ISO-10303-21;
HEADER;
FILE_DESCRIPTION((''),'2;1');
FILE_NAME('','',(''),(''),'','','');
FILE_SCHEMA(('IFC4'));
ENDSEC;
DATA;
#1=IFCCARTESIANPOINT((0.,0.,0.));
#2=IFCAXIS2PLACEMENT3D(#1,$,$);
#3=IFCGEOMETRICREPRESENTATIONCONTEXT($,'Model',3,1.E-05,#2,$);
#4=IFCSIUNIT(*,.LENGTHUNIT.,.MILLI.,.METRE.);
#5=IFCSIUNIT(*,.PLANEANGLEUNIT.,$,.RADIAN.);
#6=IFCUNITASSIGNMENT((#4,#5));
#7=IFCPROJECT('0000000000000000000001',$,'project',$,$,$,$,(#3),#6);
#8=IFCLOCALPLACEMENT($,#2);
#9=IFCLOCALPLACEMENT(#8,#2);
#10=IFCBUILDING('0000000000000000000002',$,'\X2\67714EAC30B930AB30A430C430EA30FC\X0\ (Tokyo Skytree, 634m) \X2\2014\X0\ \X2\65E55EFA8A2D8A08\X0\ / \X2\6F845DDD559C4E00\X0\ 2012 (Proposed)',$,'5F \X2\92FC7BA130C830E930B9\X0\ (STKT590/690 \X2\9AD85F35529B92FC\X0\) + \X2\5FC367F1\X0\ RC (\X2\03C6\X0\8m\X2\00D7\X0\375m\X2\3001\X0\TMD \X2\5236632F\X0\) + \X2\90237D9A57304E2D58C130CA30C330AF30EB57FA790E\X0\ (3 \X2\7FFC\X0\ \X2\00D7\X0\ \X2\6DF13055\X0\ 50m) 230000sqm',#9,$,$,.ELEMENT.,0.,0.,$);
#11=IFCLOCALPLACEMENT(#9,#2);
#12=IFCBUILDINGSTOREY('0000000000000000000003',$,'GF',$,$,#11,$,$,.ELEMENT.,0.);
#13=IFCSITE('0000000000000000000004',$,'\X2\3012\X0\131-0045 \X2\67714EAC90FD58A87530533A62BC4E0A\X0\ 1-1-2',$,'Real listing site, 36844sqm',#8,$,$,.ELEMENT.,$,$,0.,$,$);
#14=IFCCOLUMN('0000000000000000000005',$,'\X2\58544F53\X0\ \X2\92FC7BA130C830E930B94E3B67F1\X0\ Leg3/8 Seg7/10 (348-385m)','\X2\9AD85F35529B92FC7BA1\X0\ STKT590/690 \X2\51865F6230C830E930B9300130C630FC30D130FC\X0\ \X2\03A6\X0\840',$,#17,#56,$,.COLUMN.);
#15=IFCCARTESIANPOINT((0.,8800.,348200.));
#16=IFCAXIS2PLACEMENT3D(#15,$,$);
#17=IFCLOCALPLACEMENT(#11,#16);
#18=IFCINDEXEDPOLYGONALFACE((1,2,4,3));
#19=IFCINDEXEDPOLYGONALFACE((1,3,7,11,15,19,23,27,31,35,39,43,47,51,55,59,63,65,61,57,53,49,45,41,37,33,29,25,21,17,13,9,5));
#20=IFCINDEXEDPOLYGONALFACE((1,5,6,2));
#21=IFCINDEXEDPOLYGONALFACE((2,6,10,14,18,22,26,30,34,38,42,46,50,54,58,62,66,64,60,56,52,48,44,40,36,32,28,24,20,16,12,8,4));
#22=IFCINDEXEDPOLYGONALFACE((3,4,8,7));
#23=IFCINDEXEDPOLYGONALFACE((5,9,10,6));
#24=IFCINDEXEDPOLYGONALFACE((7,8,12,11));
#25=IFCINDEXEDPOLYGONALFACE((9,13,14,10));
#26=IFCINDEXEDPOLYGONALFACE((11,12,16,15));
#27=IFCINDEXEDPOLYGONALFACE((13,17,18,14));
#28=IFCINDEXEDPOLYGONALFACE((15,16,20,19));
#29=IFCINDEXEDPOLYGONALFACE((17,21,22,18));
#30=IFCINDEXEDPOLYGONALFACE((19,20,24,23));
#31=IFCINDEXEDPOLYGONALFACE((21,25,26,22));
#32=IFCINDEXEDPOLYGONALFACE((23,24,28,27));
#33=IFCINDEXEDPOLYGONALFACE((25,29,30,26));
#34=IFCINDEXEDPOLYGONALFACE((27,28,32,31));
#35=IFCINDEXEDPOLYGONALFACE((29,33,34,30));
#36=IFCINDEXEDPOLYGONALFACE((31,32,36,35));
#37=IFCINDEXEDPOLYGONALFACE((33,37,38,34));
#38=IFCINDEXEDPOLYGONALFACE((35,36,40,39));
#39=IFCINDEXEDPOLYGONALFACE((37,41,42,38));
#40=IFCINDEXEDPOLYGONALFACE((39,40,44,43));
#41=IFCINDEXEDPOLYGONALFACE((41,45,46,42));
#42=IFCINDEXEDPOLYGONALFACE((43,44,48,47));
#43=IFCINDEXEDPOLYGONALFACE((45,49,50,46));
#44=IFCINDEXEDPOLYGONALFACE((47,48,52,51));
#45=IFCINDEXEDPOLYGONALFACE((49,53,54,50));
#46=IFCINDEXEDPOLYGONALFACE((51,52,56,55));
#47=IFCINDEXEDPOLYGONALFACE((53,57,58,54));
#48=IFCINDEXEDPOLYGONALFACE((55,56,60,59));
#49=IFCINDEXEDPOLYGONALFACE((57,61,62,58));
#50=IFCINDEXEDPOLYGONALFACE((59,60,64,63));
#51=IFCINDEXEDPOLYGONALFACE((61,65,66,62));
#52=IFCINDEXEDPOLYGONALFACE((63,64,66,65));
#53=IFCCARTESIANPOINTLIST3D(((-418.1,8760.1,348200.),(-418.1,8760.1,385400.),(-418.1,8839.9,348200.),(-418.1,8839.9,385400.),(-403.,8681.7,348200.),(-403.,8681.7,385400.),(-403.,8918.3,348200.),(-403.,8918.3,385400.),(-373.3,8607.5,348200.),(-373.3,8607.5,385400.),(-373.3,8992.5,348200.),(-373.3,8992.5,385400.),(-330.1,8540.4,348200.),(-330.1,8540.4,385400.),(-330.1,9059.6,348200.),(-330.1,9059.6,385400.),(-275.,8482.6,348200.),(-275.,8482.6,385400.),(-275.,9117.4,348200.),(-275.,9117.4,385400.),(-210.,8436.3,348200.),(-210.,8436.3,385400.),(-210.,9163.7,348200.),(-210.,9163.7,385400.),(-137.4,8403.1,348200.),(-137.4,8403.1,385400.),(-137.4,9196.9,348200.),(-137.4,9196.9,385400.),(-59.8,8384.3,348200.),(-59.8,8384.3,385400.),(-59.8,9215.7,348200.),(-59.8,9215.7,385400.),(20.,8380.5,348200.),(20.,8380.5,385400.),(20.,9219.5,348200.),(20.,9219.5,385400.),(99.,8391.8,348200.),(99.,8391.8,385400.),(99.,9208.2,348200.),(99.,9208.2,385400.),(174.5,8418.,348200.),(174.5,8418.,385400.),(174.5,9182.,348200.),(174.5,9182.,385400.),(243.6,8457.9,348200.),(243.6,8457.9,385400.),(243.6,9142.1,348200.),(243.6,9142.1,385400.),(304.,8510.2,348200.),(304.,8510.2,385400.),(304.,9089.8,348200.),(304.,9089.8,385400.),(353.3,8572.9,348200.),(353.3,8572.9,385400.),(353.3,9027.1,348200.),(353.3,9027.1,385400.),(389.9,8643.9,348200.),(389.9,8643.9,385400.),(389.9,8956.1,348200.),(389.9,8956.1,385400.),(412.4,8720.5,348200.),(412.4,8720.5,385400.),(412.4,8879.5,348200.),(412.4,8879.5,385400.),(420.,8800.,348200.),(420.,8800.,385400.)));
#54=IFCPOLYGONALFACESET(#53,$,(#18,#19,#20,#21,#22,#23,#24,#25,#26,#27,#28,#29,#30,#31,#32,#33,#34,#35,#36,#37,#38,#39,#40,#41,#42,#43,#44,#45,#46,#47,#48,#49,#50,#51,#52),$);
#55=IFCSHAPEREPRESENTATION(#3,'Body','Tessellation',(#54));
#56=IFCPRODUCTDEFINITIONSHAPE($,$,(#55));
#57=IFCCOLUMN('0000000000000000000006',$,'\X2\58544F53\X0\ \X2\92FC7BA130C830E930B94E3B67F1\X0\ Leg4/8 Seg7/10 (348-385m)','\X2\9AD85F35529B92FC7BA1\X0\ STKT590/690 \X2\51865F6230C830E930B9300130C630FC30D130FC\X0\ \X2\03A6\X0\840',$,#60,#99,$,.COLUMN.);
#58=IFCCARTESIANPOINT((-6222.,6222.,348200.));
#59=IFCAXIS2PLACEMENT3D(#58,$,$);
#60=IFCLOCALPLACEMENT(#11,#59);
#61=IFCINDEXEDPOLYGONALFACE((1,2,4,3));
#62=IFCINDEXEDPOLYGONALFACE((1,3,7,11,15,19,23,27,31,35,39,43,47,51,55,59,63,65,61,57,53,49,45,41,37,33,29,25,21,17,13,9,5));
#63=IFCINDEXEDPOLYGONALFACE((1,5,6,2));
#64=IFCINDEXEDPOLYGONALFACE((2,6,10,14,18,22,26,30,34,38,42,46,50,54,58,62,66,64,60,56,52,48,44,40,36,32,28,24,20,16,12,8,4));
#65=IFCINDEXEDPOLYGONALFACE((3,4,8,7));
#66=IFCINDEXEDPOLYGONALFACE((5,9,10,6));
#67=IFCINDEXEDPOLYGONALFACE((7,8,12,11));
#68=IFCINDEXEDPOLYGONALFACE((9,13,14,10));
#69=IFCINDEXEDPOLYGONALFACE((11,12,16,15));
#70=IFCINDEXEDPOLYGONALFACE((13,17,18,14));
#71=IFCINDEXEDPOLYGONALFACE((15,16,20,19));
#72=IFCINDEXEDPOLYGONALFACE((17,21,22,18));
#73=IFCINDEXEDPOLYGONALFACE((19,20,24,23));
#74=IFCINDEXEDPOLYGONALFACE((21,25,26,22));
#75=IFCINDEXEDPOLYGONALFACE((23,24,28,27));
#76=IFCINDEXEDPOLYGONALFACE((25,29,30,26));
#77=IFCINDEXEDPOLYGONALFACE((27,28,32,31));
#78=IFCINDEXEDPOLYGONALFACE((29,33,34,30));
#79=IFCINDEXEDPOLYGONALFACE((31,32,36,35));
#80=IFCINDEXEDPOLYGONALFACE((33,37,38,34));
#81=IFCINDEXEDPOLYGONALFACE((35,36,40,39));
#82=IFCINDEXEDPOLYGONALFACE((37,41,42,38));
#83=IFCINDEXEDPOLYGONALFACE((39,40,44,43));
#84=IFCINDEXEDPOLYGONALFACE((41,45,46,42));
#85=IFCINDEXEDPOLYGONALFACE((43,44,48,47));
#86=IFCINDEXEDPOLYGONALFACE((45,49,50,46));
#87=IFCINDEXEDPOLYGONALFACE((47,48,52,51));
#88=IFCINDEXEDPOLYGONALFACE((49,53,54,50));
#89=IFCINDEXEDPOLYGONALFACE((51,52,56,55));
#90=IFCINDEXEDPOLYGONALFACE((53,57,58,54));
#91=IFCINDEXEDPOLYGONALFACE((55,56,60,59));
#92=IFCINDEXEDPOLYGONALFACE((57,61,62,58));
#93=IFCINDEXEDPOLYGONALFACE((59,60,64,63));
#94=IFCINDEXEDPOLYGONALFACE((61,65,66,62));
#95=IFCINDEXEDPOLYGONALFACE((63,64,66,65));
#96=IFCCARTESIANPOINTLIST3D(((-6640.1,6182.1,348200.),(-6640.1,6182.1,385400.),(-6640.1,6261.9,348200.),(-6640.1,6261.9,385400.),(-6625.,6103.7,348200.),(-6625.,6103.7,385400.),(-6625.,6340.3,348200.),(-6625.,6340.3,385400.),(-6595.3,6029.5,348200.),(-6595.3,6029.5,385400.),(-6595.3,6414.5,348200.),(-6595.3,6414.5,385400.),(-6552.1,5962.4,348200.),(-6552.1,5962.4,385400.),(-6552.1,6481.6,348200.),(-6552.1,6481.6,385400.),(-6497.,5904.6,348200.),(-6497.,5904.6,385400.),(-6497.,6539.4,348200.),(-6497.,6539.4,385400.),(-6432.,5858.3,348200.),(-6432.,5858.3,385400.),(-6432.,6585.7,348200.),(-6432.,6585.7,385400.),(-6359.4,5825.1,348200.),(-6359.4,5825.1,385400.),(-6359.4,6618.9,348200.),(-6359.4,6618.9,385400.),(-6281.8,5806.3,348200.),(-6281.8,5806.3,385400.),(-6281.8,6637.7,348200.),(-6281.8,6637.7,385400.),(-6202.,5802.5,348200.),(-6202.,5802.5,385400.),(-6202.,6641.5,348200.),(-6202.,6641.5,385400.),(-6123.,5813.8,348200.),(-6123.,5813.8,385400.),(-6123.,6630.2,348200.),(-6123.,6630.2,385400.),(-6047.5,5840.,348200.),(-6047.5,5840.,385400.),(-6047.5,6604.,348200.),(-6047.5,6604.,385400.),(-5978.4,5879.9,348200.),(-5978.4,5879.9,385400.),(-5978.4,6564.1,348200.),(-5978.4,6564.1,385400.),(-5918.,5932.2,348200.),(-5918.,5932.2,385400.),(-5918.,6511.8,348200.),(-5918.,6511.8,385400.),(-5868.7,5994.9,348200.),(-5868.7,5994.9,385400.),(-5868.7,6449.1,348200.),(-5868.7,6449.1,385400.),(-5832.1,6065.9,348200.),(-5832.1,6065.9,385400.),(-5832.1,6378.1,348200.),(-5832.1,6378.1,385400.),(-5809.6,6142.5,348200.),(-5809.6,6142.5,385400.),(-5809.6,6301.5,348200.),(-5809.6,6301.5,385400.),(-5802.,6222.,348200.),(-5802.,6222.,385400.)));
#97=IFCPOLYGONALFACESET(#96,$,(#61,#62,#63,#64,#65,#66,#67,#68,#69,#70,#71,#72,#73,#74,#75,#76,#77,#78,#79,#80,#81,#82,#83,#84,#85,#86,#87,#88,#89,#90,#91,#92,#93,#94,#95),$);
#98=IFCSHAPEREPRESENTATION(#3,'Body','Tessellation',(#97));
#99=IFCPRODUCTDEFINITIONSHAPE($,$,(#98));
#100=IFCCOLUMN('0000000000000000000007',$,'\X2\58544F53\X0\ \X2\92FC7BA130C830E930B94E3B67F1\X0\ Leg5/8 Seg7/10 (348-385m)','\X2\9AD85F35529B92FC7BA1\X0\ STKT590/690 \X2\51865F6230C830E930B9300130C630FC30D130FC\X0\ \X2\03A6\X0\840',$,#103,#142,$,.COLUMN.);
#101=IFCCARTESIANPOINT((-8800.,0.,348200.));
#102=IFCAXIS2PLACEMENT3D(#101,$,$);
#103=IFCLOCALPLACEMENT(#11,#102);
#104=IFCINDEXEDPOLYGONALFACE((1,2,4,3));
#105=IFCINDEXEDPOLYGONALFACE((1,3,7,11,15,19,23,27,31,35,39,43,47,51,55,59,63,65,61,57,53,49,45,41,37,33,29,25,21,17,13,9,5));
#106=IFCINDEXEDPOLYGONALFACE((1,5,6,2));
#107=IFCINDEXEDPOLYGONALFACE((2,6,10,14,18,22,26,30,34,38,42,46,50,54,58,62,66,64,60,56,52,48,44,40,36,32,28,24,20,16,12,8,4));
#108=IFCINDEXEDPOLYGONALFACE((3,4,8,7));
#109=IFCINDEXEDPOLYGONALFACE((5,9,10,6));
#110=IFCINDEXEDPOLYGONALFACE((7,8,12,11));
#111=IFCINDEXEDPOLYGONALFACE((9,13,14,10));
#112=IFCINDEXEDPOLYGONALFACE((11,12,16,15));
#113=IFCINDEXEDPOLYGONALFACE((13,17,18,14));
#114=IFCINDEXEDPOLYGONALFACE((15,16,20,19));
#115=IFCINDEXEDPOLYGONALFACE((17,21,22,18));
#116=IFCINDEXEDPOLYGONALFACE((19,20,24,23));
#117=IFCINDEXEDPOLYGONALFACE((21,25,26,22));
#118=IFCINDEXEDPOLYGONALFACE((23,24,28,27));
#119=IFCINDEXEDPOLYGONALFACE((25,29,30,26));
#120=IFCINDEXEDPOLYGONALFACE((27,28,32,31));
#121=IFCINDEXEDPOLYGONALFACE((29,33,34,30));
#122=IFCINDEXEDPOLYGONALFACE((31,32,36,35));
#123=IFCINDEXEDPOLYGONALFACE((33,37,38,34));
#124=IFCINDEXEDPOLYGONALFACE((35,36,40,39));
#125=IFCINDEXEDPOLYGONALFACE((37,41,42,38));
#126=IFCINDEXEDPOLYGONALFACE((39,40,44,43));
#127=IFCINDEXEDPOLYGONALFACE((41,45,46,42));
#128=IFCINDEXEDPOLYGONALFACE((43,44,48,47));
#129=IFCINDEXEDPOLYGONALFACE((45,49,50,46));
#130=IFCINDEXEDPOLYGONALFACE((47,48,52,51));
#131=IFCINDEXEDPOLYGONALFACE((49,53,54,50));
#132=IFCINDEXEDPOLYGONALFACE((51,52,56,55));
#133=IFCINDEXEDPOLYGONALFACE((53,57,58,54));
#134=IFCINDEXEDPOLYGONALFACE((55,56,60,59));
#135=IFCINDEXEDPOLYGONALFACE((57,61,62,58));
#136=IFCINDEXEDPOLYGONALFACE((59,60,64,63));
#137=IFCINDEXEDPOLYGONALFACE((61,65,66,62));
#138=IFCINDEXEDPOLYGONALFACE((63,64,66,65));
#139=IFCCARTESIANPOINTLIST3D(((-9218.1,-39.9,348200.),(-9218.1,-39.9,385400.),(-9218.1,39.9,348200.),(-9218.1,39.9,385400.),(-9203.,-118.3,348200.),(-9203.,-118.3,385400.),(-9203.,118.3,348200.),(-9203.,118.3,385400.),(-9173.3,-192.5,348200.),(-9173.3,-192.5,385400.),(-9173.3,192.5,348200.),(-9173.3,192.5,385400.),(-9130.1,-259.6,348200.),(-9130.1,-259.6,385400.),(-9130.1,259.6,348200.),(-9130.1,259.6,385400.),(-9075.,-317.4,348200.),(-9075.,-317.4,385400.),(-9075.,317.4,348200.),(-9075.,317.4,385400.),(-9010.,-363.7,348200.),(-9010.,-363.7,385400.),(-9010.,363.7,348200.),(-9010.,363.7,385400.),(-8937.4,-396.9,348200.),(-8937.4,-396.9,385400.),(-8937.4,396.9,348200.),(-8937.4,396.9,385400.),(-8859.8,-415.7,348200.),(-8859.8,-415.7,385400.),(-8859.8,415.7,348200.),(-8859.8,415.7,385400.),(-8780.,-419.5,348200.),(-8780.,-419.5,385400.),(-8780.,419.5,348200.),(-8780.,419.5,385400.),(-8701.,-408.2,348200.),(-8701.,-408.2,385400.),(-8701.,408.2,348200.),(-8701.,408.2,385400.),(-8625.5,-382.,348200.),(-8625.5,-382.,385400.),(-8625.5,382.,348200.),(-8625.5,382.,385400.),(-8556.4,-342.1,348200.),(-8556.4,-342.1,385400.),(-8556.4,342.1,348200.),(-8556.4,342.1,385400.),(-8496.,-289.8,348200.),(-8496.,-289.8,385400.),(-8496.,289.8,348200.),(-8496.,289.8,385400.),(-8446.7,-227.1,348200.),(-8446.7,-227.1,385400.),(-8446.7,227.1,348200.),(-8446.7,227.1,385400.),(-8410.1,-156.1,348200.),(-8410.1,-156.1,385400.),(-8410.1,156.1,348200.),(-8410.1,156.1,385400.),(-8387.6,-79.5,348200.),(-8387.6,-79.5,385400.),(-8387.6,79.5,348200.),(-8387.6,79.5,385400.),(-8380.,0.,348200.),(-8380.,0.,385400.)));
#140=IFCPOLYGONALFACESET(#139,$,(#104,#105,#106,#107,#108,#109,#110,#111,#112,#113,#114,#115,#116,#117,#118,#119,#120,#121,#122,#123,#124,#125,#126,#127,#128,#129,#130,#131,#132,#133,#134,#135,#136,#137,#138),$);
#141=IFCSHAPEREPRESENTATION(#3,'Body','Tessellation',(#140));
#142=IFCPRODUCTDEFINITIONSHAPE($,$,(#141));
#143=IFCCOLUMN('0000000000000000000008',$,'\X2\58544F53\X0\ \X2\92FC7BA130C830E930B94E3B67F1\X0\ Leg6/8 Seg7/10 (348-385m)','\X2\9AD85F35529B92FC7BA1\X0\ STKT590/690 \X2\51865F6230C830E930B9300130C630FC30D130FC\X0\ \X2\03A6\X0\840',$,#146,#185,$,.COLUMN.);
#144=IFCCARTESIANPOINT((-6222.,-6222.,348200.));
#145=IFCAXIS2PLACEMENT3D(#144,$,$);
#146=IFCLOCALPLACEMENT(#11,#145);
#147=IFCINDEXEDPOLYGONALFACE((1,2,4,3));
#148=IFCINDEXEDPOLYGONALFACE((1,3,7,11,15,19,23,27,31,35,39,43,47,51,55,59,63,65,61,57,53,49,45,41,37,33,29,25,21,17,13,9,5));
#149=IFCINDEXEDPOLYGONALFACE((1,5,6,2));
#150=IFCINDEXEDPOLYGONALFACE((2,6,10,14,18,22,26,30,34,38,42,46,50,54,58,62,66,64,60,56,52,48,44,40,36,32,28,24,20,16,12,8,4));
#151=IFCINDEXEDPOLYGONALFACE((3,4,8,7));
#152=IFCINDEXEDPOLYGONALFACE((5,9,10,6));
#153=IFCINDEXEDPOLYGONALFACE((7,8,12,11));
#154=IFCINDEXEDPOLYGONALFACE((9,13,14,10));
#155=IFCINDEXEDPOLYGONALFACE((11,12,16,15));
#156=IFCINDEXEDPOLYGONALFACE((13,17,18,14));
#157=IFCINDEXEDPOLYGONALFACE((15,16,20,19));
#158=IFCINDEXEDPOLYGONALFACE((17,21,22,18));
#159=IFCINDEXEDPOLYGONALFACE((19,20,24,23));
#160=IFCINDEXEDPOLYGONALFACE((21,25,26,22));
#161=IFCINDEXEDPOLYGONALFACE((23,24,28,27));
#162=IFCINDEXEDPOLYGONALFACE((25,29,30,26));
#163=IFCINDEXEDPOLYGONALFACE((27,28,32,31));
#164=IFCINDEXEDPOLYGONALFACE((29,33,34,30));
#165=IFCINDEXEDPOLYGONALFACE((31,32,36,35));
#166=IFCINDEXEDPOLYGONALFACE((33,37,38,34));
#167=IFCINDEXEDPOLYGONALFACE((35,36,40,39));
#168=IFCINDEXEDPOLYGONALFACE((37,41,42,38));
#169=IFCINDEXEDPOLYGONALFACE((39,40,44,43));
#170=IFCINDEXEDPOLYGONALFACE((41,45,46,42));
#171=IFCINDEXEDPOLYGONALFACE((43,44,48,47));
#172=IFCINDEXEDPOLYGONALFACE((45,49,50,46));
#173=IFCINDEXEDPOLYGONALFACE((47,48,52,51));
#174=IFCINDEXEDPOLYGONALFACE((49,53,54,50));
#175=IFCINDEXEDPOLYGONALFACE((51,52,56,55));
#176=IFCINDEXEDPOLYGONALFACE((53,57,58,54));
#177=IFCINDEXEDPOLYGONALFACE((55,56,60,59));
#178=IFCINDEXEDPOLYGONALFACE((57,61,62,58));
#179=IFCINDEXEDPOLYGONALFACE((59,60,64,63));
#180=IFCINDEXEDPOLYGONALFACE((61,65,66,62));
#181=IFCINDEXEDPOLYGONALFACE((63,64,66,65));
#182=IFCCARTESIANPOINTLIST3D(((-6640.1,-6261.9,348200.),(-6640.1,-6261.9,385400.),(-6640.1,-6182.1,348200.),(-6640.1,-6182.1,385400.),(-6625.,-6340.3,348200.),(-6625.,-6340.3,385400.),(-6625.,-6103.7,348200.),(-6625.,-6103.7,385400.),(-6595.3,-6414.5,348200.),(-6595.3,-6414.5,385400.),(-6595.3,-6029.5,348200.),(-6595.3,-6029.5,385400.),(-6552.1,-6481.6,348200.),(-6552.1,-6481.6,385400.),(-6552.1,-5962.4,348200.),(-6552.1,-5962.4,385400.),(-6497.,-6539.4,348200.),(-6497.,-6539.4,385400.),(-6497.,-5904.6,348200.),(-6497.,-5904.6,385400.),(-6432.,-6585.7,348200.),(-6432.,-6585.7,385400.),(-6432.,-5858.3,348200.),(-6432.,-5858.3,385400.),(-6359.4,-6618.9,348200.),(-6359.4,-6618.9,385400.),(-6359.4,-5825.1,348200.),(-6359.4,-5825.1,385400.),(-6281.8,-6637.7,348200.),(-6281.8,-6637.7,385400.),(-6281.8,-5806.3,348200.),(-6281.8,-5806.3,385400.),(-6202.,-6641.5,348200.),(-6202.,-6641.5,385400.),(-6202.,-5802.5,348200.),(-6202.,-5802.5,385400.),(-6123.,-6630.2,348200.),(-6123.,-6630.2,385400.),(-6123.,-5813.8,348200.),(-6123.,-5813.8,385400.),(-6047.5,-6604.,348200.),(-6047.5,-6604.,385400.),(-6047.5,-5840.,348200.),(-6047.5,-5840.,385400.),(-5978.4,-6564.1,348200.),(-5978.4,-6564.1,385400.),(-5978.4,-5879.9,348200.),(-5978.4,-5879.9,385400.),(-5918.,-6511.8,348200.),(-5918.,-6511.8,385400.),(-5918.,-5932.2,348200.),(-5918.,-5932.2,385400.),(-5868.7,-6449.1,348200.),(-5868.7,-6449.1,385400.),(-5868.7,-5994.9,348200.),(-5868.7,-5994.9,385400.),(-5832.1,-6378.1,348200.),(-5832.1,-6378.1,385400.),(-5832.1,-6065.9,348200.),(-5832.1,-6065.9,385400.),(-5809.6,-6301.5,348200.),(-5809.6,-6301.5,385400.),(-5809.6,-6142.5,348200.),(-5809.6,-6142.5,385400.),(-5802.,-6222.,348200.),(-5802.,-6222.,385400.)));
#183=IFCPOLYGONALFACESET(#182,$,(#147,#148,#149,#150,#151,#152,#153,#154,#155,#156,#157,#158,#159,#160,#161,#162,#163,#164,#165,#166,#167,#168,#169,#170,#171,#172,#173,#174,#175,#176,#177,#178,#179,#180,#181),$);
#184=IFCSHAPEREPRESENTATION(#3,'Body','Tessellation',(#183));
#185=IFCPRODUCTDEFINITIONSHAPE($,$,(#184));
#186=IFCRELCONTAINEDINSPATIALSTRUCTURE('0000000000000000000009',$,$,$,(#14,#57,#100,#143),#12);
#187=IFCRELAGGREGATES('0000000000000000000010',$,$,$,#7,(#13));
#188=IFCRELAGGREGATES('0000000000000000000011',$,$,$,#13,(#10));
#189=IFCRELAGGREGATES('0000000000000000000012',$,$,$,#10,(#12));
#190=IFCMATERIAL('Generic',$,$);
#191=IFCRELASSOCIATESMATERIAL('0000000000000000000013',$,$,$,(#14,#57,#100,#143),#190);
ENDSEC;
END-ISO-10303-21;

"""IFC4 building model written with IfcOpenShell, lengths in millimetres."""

from ifc_helpers import new_model, si_unit, frame, origin, origin_2d, place, context, project, spatial, circle, extrude, material, element, save


model = new_model("IFC4")

# Units and contexts
model_context = context("Model", 3, precision=1e-05, world=origin())
ifc_project = project(units=[si_unit("LENGTHUNIT", "METRE", prefix="MILLI"), si_unit("PLANEANGLEUNIT", "RADIAN")], contexts=[model_context])

# Site, building, storey
site_placement = place(None, origin())
site = spatial("IfcSite", under=ifc_project, at=site_placement, Name="〒131-0045 東京都墨田区押上 1-1-2", ObjectType="Real listing site, 36844sqm", CompositionType="ELEMENT", RefElevation=0.0)
building_placement = place(site_placement, origin())
building = spatial("IfcBuilding", under=site, at=building_placement, Name="東京スカイツリー (Tokyo Skytree, 634m) — 日建設計 / 澄川喜一 2012 (Proposed)", ObjectType="5F 鋼管トラス (STKT590/690 高張力鋼) + 心柱 RC (φ8m×375m、TMD 制振) + 連続地中壁ナックル基礎 (3 翼 × 深さ 50m) 230000sqm", CompositionType="ELEMENT", ElevationOfRefHeight=0.0, ElevationOfTerrain=0.0)
storey_placement = place(building_placement, origin())
storey = spatial("IfcBuildingStorey", under=building, at=storey_placement, Name="GF", CompositionType="ELEMENT", Elevation=0.0)

# Columns
ifc_material_1 = material(Name="Generic")
column_1_placement = place(storey_placement, frame((0.0, 8800.0, 348200.0)))
element("IfcColumn", 1, at=column_1_placement, inside=storey, material=ifc_material_1, Name="塔体 鋼管トラス主柱 Leg3/8 Seg7/10 (348-385m)", Description="高張力鋼管 STKT590/690 円形トラス、テーパー Φ840", PredefinedType="COLUMN", context=model_context, shape_type="SweptSolid", body=[
    extrude(circle(Radius=420.0, at=origin_2d()), frame((0.0, 8800.0, 348200.0)), (0.0, 0.0, 1.0), 37200.0),
])
column_2_placement = place(storey_placement, frame((-6222.0, 6222.0, 348200.0)))
element("IfcColumn", 2, at=column_2_placement, inside=storey, material=ifc_material_1, Name="塔体 鋼管トラス主柱 Leg4/8 Seg7/10 (348-385m)", Description="高張力鋼管 STKT590/690 円形トラス、テーパー Φ840", PredefinedType="COLUMN", context=model_context, shape_type="SweptSolid", body=[
    extrude(circle(Radius=420.0, at=origin_2d()), frame((-6222.0, 6222.0, 348200.0)), (0.0, 0.0, 1.0), 37200.0),
])
column_3_placement = place(storey_placement, frame((-8800.0, 0.0, 348200.0)))
element("IfcColumn", 3, at=column_3_placement, inside=storey, material=ifc_material_1, Name="塔体 鋼管トラス主柱 Leg5/8 Seg7/10 (348-385m)", Description="高張力鋼管 STKT590/690 円形トラス、テーパー Φ840", PredefinedType="COLUMN", context=model_context, shape_type="SweptSolid", body=[
    extrude(circle(Radius=420.0, at=origin_2d()), frame((-8800.0, 0.0, 348200.0)), (0.0, 0.0, 1.0), 37200.0),
])
column_4_placement = place(storey_placement, frame((-6222.0, -6222.0, 348200.0)))
element("IfcColumn", 4, at=column_4_placement, inside=storey, material=ifc_material_1, Name="塔体 鋼管トラス主柱 Leg6/8 Seg7/10 (348-385m)", Description="高張力鋼管 STKT590/690 円形トラス、テーパー Φ840", PredefinedType="COLUMN", context=model_context, shape_type="SweptSolid", body=[
    extrude(circle(Radius=420.0, at=origin_2d()), frame((-6222.0, -6222.0, 348200.0)), (0.0, 0.0, 1.0), 37200.0),
])

save(model, "model.ifc")
